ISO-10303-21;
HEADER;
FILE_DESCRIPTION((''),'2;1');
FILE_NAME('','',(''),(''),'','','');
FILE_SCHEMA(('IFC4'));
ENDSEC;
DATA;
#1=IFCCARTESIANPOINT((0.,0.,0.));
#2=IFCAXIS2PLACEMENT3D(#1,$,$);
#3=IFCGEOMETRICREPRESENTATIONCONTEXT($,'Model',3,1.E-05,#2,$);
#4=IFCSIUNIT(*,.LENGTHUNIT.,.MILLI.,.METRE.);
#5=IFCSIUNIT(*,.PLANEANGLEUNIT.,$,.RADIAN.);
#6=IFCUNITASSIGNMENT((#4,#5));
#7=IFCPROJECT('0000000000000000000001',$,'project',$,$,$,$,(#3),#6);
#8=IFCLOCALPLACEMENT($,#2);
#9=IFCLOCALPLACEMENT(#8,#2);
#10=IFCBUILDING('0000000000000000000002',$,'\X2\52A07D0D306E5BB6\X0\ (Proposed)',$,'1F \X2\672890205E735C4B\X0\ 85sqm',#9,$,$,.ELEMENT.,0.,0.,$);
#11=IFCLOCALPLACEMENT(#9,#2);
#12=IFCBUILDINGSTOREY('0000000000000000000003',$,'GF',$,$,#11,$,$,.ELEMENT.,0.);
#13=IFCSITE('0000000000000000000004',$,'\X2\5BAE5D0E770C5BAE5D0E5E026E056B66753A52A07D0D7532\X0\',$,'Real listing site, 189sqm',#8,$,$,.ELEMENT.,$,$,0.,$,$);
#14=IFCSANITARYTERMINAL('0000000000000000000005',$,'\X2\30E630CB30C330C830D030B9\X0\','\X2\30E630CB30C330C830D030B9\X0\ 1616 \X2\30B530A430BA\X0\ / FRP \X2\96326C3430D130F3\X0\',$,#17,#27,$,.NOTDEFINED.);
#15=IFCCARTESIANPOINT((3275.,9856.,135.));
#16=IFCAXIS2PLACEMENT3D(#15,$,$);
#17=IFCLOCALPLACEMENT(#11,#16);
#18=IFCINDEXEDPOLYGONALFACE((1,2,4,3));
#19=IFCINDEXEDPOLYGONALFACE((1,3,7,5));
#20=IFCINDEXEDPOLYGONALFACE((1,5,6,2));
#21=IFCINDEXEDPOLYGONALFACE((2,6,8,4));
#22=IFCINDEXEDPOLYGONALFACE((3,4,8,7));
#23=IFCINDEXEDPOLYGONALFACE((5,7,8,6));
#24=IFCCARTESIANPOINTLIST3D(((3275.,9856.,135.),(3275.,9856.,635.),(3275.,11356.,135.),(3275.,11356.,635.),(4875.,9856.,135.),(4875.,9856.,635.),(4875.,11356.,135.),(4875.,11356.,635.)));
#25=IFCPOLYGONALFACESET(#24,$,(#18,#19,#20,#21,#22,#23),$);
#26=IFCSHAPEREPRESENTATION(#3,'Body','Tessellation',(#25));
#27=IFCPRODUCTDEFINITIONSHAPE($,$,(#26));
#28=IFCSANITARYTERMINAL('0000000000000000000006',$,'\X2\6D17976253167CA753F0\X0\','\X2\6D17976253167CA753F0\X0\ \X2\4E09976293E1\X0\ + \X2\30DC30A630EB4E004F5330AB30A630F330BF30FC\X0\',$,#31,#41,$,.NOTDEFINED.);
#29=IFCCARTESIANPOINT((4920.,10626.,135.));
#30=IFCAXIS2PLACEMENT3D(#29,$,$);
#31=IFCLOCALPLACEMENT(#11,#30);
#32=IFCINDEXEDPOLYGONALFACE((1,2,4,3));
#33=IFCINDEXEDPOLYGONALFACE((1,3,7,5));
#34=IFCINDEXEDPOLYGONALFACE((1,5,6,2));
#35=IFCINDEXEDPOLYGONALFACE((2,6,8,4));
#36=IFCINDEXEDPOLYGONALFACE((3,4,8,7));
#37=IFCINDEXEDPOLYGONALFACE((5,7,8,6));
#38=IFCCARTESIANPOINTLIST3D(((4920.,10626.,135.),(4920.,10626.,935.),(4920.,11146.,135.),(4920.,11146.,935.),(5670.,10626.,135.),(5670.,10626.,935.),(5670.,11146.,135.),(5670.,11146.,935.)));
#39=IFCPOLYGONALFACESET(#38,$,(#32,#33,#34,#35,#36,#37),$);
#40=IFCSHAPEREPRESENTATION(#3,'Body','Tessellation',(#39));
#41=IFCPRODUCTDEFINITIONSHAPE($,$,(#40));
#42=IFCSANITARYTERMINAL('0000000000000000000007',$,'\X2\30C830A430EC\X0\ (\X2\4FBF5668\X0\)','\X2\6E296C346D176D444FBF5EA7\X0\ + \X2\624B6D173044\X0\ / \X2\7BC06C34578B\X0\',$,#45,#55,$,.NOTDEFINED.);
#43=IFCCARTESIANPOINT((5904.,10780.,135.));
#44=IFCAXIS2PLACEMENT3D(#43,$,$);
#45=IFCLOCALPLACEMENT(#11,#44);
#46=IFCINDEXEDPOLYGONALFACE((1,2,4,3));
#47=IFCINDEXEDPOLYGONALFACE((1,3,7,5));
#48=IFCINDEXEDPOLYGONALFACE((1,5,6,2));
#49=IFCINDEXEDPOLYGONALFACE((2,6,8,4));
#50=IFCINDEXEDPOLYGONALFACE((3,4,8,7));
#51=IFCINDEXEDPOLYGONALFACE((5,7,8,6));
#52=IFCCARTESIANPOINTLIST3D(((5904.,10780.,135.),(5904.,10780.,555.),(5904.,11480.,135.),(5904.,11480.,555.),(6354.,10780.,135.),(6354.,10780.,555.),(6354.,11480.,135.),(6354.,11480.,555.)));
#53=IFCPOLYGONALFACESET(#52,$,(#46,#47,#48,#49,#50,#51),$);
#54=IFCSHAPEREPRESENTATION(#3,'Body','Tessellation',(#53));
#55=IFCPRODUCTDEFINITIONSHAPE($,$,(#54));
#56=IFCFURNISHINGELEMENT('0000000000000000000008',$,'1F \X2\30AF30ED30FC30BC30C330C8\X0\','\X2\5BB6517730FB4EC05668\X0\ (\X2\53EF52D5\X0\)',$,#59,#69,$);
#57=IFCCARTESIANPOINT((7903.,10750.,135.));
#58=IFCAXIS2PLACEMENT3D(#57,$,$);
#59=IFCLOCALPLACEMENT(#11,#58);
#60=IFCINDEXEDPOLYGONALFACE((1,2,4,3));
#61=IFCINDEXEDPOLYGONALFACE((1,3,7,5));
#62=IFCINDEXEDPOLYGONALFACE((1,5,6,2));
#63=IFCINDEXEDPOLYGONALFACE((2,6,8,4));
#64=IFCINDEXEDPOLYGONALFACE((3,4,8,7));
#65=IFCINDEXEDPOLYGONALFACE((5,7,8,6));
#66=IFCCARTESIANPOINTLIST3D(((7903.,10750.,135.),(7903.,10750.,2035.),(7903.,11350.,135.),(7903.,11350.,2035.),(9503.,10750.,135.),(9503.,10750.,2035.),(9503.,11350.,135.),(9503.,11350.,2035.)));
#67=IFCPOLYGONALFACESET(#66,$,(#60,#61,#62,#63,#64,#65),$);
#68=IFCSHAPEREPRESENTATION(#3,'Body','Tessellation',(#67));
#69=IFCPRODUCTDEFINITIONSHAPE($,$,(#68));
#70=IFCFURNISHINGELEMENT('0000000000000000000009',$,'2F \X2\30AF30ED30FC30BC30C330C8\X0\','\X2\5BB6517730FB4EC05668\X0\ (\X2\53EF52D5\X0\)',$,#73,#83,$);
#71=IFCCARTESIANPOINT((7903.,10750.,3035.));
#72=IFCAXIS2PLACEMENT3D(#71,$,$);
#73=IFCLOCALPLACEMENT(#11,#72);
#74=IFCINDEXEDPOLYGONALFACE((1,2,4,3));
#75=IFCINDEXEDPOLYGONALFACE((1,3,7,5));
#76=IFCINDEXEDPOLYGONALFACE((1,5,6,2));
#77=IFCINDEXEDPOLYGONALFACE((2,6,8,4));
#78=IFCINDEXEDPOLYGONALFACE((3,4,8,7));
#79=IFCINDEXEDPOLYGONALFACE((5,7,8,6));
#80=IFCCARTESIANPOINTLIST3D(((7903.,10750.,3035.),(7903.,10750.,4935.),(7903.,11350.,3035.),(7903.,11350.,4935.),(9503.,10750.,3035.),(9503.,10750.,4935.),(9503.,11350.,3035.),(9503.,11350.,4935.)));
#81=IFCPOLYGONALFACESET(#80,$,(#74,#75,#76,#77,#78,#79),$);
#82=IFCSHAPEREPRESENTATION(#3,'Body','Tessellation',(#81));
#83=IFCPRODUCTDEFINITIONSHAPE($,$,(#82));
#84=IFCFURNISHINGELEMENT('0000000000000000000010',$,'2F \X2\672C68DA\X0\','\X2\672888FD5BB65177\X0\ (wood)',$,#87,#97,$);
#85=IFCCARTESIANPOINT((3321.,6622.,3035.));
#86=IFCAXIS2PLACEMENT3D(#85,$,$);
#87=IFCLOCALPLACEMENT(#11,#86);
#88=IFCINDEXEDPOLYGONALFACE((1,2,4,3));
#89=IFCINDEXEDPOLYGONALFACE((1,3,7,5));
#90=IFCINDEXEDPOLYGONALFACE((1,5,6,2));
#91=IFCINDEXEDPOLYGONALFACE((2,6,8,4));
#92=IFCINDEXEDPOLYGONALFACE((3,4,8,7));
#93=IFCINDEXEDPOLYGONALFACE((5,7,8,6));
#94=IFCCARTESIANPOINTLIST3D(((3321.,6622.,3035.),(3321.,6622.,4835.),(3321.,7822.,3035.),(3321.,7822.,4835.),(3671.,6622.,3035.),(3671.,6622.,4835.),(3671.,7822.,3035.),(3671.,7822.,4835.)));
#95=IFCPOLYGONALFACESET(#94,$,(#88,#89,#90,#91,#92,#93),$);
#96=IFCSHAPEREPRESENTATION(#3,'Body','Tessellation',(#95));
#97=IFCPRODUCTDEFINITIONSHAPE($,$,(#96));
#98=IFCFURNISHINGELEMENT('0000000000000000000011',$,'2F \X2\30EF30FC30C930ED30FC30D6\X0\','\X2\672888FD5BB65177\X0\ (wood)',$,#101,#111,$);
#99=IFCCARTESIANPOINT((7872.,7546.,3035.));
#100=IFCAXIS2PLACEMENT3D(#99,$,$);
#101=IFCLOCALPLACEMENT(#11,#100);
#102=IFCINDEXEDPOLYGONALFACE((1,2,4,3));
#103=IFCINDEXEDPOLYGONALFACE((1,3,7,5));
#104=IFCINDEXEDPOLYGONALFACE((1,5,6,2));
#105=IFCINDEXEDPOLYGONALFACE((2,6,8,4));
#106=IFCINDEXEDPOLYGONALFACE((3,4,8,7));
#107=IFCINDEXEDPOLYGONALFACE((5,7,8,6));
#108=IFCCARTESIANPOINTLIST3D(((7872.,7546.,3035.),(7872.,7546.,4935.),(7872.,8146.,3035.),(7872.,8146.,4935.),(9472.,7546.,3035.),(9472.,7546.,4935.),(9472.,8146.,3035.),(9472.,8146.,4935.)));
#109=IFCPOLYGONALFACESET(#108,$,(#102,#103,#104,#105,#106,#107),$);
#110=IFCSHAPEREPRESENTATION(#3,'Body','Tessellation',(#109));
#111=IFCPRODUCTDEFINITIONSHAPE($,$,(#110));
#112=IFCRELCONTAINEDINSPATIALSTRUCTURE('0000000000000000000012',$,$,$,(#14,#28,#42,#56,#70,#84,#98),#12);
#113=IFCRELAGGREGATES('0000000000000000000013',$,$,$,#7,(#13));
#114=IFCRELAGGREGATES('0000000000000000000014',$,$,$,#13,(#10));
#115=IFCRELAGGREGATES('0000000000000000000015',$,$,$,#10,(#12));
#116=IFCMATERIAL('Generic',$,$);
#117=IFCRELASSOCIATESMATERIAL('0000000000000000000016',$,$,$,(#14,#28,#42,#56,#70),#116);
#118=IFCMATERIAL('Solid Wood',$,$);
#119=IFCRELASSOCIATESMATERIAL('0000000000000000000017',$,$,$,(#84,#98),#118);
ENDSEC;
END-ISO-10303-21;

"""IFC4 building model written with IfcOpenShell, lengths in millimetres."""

from ifc_helpers import new_model, si_unit, frame, frame_2d, origin, place, context, project, spatial, rectangle, extrude, material, element, save


model = new_model("IFC4")

# Units and contexts
model_context = context("Model", 3, precision=1e-05, world=origin())
ifc_project = project(units=[si_unit("LENGTHUNIT", "METRE", prefix="MILLI"), si_unit("PLANEANGLEUNIT", "RADIAN")], contexts=[model_context])

# Site, building, storey
site_placement = place(None, origin())
site = spatial("IfcSite", under=ifc_project, at=site_placement, Name="宮崎県宮崎市清武町加納甲", ObjectType="Real listing site, 189sqm", CompositionType="ELEMENT", RefElevation=0.0)
building_placement = place(site_placement, origin())
building = spatial("IfcBuilding", under=site, at=building_placement, Name="加納の家 (Proposed)", ObjectType="1F 木造平屋 85sqm", CompositionType="ELEMENT", ElevationOfRefHeight=0.0, ElevationOfTerrain=0.0)
storey_placement = place(building_placement, origin())
storey = spatial("IfcBuildingStorey", under=building, at=storey_placement, Name="GF", CompositionType="ELEMENT", Elevation=0.0)

# Shared definitions
ifc_material_1 = material(Name="Solid Wood")

# Shared definitions
ifc_material_2 = material(Name="Generic")

# Sanitary terminals
sanitary_terminal_1_placement = place(storey_placement, frame((3275.0, 9856.0, 135.0)))
element("IfcSanitaryTerminal", 1, at=sanitary_terminal_1_placement, inside=storey, material=ifc_material_2, Name="ユニットバス", Description="ユニットバス 1616 サイズ / FRP 防水パン", PredefinedType="NOTDEFINED", context=model_context, shape_type="SweptSolid", body=[
    extrude(rectangle(XDim=1600.0, YDim=1500.0, at=frame_2d((800.0, 750.0))), frame((3275.0, 9856.0, 135.0)), (0.0, 0.0, 1.0), 500.0),
])
sanitary_terminal_2_placement = place(storey_placement, frame((4920.0, 10626.0, 135.0)))
element("IfcSanitaryTerminal", 2, at=sanitary_terminal_2_placement, inside=storey, material=ifc_material_2, Name="洗面化粧台", Description="洗面化粧台 三面鏡 + ボウル一体カウンター", PredefinedType="NOTDEFINED", context=model_context, shape_type="SweptSolid", body=[
    extrude(rectangle(XDim=750.0, YDim=520.0, at=frame_2d((375.0, 260.0))), frame((4920.0, 10626.0, 135.0)), (0.0, 0.0, 1.0), 800.0),
])
sanitary_terminal_3_placement = place(storey_placement, frame((5904.0, 10780.0, 135.0)))
element("IfcSanitaryTerminal", 3, at=sanitary_terminal_3_placement, inside=storey, material=ifc_material_2, Name="トイレ (便器)", Description="温水洗浄便座 + 手洗い / 節水型", PredefinedType="NOTDEFINED", context=model_context, shape_type="SweptSolid", body=[
    extrude(rectangle(XDim=450.0, YDim=700.0, at=frame_2d((225.0, 350.0))), frame((5904.0, 10780.0, 135.0)), (0.0, 0.0, 1.0), 420.0),
])

# Furnishing elements
furnishing_1_placement = place(storey_placement, frame((7903.0, 10750.0, 135.0)))
element("IfcFurnishingElement", 4, at=furnishing_1_placement, inside=storey, material=ifc_material_2, Name="1F クローゼット", Description="家具・什器 (可動)", context=model_context, shape_type="SweptSolid", body=[
    extrude(rectangle(XDim=1600.0, YDim=600.0, at=frame_2d((800.0, 300.0))), frame((7903.0, 10750.0, 135.0)), (0.0, 0.0, 1.0), 1900.0),
])
furnishing_2_placement = place(storey_placement, frame((7903.0, 10750.0, 3035.0)))
element("IfcFurnishingElement", 5, at=furnishing_2_placement, inside=storey, material=ifc_material_2, Name="2F クローゼット", Description="家具・什器 (可動)", context=model_context, shape_type="SweptSolid", body=[
    extrude(rectangle(XDim=1600.0, YDim=600.0, at=frame_2d((800.0, 300.0))), frame((7903.0, 10750.0, 3035.0)), (0.0, 0.0, 1.0), 1900.0),
])
furnishing_3_placement = place(storey_placement, frame((3321.0, 6622.0, 3035.0)))
element("IfcFurnishingElement", 6, at=furnishing_3_placement, inside=storey, material=ifc_material_1, Name="2F 本棚", Description="木製家具 (wood)", context=model_context, shape_type="SweptSolid", body=[
    extrude(rectangle(XDim=350.0, YDim=1200.0, at=frame_2d((175.0, 600.0))), frame((3321.0, 6622.0, 3035.0)), (0.0, 0.0, 1.0), 1800.0),
])
furnishing_4_placement = place(storey_placement, frame((7872.0, 7546.0, 3035.0)))
element("IfcFurnishingElement", 7, at=furnishing_4_placement, inside=storey, material=ifc_material_1, Name="2F ワードローブ", Description="木製家具 (wood)", context=model_context, shape_type="SweptSolid", body=[
    extrude(rectangle(XDim=1600.0, YDim=600.0, at=frame_2d((800.0, 300.0))), frame((7872.0, 7546.0, 3035.0)), (0.0, 0.0, 1.0), 1900.0),
])

save(model, "model.ifc")
